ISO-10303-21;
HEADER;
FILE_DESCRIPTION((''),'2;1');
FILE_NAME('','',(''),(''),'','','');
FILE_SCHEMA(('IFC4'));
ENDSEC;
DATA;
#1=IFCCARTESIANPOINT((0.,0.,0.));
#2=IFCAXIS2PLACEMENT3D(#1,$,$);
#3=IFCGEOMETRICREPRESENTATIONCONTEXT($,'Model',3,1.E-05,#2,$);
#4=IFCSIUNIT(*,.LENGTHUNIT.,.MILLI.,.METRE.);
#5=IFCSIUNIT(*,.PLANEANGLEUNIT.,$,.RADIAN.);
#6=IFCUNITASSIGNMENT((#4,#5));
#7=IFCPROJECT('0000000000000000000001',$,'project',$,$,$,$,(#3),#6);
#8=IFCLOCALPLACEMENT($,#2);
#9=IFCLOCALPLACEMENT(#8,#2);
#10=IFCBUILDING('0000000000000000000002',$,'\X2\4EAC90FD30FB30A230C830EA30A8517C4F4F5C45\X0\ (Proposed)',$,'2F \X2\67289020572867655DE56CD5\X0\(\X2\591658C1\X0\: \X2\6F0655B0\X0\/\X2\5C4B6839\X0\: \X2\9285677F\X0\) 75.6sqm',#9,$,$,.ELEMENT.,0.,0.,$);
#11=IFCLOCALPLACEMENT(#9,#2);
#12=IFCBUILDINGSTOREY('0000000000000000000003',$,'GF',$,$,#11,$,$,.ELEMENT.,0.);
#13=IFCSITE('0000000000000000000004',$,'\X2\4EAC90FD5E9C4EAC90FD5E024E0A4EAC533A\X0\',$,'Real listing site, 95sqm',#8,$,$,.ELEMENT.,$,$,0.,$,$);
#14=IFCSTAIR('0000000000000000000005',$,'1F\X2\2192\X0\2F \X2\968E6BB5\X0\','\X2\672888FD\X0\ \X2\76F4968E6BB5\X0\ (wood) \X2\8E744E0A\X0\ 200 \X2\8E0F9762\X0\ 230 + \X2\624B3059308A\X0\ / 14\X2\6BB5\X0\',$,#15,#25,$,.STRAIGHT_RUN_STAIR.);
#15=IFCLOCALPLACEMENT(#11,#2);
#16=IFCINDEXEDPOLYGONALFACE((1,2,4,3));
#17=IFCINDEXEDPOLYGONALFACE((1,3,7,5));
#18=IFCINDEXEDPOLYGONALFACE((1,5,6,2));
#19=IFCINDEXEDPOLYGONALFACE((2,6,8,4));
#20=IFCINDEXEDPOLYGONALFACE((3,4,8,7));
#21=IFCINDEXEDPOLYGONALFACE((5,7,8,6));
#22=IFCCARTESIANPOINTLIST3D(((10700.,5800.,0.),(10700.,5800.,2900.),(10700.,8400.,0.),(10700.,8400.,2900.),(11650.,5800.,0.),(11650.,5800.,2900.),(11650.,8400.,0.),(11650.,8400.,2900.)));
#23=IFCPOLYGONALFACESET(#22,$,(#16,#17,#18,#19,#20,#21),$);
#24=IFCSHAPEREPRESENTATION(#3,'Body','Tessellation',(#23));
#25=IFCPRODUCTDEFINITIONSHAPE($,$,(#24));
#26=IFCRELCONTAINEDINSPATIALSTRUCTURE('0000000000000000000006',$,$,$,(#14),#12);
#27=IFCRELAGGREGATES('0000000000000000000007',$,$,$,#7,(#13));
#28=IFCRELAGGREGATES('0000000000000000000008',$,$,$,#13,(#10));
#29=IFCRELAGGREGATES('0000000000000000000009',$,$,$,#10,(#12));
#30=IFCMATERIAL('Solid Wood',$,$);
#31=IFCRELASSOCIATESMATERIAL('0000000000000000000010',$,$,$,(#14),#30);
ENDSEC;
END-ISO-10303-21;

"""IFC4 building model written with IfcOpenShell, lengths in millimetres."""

from ifc_helpers import new_model, si_unit, frame, frame_2d, origin, place, context, project, spatial, rectangle, extrude, material, element, save


model = new_model("IFC4")

# Units and contexts
model_context = context("Model", 3, precision=1e-05, world=origin())
ifc_project = project(units=[si_unit("LENGTHUNIT", "METRE", prefix="MILLI"), si_unit("PLANEANGLEUNIT", "RADIAN")], contexts=[model_context])

# Site, building, storey
site_placement = place(None, origin())
site = spatial("IfcSite", under=ifc_project, at=site_placement, Name="京都府京都市上京区", ObjectType="Real listing site, 95sqm", CompositionType="ELEMENT", RefElevation=0.0)
building_placement = place(site_placement, origin())
building = spatial("IfcBuilding", under=site, at=building_placement, Name="京都・アトリエ兼住居 (Proposed)", ObjectType="2F 木造在来工法(外壁: 漆喰/屋根: 銅板) 75.6sqm", CompositionType="ELEMENT", ElevationOfRefHeight=0.0, ElevationOfTerrain=0.0)
storey_placement = place(building_placement, origin())
storey = spatial("IfcBuildingStorey", under=building, at=storey_placement, Name="GF", CompositionType="ELEMENT", Elevation=0.0)

# Shared definitions
ifc_material_1 = material(Name="Solid Wood")

# Stair
stair_placement = place(storey_placement, frame((5350.0, 2900.0, 0.0)))
element("IfcStair", 1, at=stair_placement, inside=storey, material=ifc_material_1, Name="1F→2F 階段", Description="木製 直階段 (wood) 蹴上 200 踏面 230 + 手すり / 14段", PredefinedType="STRAIGHT_RUN_STAIR", context=model_context, shape_type="SweptSolid", body=[
    extrude(rectangle(XDim=950.0, YDim=2600.0, at=frame_2d((475.0, 1300.0))), frame((5350.0, 2900.0, 0.0)), (0.0, 0.0, 1.0), 2900.0),
])

save(model, "model.ifc")
